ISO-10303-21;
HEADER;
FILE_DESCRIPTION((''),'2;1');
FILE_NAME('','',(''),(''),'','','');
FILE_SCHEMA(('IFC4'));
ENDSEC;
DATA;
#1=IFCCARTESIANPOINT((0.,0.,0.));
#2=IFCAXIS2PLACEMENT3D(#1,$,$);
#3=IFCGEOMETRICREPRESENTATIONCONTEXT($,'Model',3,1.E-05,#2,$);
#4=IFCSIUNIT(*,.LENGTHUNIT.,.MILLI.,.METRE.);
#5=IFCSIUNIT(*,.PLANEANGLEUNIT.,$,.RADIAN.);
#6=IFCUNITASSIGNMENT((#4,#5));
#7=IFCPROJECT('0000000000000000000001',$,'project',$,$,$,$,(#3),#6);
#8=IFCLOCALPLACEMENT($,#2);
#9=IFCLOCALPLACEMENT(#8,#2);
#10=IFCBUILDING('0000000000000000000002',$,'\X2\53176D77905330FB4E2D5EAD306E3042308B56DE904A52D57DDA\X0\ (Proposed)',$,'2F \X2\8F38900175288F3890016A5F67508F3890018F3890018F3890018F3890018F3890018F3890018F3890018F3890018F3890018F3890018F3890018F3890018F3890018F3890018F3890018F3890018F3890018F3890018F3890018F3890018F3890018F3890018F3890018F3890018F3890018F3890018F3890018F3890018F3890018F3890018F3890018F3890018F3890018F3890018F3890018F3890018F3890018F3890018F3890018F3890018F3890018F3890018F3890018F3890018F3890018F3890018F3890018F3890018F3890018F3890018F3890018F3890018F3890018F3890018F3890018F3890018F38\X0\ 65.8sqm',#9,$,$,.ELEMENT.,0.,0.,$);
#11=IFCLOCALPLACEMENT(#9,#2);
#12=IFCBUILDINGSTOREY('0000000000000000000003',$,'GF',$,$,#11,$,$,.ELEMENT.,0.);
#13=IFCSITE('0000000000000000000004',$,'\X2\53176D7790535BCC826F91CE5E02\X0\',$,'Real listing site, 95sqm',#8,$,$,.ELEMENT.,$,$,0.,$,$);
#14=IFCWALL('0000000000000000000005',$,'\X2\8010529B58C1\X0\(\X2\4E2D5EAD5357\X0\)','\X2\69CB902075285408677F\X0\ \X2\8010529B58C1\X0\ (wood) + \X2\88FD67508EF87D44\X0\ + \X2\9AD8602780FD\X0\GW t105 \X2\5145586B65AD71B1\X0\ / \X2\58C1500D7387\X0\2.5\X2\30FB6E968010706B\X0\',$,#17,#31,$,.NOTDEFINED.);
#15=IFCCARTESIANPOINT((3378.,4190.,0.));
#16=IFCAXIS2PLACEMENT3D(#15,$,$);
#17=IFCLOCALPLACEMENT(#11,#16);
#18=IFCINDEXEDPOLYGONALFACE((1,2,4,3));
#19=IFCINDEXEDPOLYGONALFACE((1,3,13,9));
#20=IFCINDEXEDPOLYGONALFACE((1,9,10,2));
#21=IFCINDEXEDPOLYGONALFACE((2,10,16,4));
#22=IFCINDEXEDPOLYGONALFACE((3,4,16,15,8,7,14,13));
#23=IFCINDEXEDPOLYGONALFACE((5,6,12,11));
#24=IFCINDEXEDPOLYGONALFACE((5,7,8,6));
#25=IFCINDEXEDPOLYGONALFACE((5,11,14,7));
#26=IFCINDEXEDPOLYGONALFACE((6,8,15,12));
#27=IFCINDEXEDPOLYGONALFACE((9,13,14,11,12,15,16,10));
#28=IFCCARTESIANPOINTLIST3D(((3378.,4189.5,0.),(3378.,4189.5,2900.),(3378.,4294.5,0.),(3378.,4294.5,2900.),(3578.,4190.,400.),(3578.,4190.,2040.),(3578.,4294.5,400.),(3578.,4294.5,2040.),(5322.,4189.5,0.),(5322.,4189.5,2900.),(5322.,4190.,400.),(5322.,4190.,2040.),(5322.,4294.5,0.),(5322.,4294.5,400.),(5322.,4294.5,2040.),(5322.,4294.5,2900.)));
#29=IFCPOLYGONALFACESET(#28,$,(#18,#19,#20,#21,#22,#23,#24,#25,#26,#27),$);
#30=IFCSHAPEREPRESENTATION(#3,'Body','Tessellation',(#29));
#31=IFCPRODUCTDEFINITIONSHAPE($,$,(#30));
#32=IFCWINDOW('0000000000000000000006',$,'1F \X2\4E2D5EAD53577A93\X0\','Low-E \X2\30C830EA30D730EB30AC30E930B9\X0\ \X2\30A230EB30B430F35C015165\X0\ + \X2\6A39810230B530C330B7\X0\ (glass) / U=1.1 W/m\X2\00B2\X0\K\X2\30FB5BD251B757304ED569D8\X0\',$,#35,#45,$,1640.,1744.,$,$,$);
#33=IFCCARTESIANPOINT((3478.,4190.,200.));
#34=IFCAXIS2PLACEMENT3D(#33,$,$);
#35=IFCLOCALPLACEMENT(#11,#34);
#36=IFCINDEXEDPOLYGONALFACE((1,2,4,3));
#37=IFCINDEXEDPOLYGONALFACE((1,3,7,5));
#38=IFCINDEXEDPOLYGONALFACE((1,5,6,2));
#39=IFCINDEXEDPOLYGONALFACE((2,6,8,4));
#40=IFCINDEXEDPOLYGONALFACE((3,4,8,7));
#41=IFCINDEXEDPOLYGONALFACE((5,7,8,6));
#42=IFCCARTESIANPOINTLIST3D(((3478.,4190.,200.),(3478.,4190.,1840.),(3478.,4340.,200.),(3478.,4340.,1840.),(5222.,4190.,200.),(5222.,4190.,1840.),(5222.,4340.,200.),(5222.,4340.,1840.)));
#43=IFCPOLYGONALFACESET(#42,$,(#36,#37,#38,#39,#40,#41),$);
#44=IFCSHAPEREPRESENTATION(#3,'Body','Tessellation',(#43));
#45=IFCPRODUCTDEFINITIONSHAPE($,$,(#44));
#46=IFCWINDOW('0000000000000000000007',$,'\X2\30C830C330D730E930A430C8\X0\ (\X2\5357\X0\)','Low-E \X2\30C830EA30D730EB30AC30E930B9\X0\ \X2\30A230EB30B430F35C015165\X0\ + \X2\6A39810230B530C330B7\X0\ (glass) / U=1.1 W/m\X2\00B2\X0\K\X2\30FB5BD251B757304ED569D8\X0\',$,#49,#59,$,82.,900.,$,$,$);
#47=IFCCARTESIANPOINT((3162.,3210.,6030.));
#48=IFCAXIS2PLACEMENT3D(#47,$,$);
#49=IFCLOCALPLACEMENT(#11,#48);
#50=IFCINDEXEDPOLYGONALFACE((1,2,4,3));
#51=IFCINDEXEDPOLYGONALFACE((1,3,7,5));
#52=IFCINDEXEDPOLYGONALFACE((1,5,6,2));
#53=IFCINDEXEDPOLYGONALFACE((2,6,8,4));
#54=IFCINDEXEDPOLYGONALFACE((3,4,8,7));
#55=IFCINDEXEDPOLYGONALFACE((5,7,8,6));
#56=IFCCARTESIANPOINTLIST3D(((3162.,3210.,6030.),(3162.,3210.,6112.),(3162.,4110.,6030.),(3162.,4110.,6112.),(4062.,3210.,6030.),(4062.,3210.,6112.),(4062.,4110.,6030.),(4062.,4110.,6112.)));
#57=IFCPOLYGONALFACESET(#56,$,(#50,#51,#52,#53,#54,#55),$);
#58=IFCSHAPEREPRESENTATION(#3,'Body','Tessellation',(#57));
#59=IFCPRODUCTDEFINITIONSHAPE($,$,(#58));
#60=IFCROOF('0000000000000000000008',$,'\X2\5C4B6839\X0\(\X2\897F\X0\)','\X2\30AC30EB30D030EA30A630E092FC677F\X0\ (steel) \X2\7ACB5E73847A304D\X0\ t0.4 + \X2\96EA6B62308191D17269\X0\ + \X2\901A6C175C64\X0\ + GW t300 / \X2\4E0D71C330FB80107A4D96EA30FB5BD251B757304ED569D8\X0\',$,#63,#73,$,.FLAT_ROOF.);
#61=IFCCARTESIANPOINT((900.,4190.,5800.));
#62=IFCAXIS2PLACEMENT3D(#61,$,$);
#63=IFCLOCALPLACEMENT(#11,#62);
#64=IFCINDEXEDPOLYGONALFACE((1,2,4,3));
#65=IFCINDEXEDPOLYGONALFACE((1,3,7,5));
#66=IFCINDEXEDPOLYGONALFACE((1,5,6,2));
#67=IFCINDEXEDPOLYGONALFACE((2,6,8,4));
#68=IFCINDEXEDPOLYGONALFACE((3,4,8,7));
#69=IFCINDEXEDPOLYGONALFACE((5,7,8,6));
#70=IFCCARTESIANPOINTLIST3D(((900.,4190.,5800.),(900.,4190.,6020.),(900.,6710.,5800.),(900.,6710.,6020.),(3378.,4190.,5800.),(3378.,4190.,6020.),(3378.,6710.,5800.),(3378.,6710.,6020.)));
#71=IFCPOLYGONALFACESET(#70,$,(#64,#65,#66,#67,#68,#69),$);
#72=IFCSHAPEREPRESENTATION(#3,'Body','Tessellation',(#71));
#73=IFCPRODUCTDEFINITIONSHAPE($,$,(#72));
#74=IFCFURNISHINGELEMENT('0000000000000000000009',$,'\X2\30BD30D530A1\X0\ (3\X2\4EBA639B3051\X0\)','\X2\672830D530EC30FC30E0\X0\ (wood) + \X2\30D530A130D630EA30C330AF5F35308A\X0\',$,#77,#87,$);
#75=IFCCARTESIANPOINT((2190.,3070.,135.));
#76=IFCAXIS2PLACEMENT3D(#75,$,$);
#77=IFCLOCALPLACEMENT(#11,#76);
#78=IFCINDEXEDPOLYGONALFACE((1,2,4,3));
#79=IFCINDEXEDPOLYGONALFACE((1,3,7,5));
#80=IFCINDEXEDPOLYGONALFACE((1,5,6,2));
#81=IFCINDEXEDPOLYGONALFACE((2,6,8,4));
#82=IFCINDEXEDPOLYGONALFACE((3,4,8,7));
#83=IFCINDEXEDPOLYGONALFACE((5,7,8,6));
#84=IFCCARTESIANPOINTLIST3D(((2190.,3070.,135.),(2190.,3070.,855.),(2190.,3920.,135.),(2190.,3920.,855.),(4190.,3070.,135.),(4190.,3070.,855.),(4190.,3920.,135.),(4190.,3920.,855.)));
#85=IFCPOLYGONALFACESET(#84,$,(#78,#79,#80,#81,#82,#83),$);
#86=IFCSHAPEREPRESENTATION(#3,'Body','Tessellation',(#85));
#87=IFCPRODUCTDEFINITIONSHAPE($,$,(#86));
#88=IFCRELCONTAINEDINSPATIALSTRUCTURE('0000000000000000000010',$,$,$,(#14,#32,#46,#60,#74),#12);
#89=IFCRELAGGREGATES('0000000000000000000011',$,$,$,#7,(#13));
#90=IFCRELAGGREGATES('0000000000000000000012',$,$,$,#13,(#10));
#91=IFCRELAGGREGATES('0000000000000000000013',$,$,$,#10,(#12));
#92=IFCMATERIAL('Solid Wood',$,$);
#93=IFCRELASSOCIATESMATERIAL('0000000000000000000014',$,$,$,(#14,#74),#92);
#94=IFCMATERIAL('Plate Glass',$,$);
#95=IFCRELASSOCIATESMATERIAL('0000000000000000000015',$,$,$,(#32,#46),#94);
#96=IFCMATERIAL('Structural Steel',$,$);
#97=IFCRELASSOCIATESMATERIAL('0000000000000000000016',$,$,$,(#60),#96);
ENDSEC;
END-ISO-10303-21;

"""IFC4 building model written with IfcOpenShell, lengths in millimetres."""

from ifc_helpers import new_model, si_unit, frame, frame_2d, origin, place, context, project, spatial, rectangle, extrude, material, element, fill, save


model = new_model("IFC4")

# Units and contexts
model_context = context("Model", 3, precision=1e-05, world=origin())
ifc_project = project(units=[si_unit("LENGTHUNIT", "METRE", prefix="MILLI"), si_unit("PLANEANGLEUNIT", "RADIAN")], contexts=[model_context])

# Site, building, storey
site_placement = place(None, origin())
site = spatial("IfcSite", under=ifc_project, at=site_placement, Name="北海道富良野市", ObjectType="Real listing site, 95sqm", CompositionType="ELEMENT", RefElevation=0.0)
building_placement = place(site_placement, origin())
building = spatial("IfcBuilding", under=site, at=building_placement, Name="北海道・中庭のある回遊動線 (Proposed)", ObjectType="2F 輸送用輸送機材輸送輸送輸送輸送輸送輸送輸送輸送輸送輸送輸送輸送輸送輸送輸送輸送輸送輸送輸送輸送輸送輸送輸送輸送輸送輸送輸送輸送輸送輸送輸送輸送輸送輸送輸送輸送輸送輸送輸送輸送輸送輸送輸送輸送輸送輸送輸送輸送輸送輸送輸送輸送輸送輸送輸送輸送輸 65.8sqm", CompositionType="ELEMENT", ElevationOfRefHeight=0.0, ElevationOfTerrain=0.0)
storey_placement = place(building_placement, origin())
storey = spatial("IfcBuildingStorey", under=building, at=storey_placement, Name="GF", CompositionType="ELEMENT", Elevation=0.0)

# Shared definitions
ifc_material_1 = material(Name="Solid Wood")

# Wall, opening, window
wall_placement = place(storey_placement, frame((3378.0, 4190.0, 0.0)))
wall = element("IfcWall", 1, at=wall_placement, inside=storey, material=ifc_material_1, Name="耐力壁(中庭南)", Description="構造用合板 耐力壁 (wood) + 製材軸組 + 高性能GW t105 充填断熱 / 壁倍率2.5・準耐火", PredefinedType="NOTDEFINED", context=model_context, shape_type="SweptSolid", body=[
    extrude(rectangle(XDim=1944.0, YDim=105.0, at=frame_2d((972.0, 52.0))), frame((3378.0, 4190.0, 0.0)), (0.0, 0.0, 1.0), 2900.0),
])
opening_placement = place(storey_placement, frame((3478.0, 4190.0, 200.0)))
opening = element("IfcOpeningElement", 2, at=opening_placement, cuts=wall, PredefinedType="NOTDEFINED", context=model_context, shape_type="SweptSolid", body=[
    extrude(rectangle(XDim=1744.0, YDim=150.0, at=frame_2d((872.0, 75.0))), frame((3478.0, 4190.0, 200.0)), (0.0, 0.0, 1.0), 1640.0),
])
ifc_material_2 = material(Name="Plate Glass")
window_1_placement = place(storey_placement, frame((3478.0, 4190.0, 200.0)))
window_1 = element("IfcWindow", 3, at=window_1_placement, inside=storey, material=ifc_material_2, Name="1F 中庭南窓", Description="Low-E トリプルガラス アルゴン封入 + 樹脂サッシ (glass) / U=1.1 W/m²K・寒冷地仕様", OverallHeight=1640.0, OverallWidth=1744.0, context=model_context, shape_type="SweptSolid", body=[
    extrude(rectangle(XDim=1744.0, YDim=150.0, at=frame_2d((872.0, 75.0))), frame((3478.0, 4190.0, 200.0)), (0.0, 0.0, 1.0), 1640.0),
])
fill(opening, window_1)

# Window
window_2_placement = place(storey_placement, frame((3162.0, 3210.0, 6030.0)))
element("IfcWindow", 4, at=window_2_placement, inside=storey, material=ifc_material_2, Name="トップライト (南)", Description="Low-E トリプルガラス アルゴン封入 + 樹脂サッシ (glass) / U=1.1 W/m²K・寒冷地仕様", OverallHeight=82.0, OverallWidth=900.0, context=model_context, shape_type="SweptSolid", body=[
    extrude(rectangle(XDim=900.0, YDim=900.0, at=frame_2d((450.0, 450.0))), frame((3162.0, 3210.0, 6030.0)), (0.0, 0.0, 1.0), 82.0),
])

# Roof
ifc_material_3 = material(Name="Structural Steel")
for number, where, name in (
    (5, (900.0, 4190.0, 5800.0), "屋根(西)"),
):
    element("IfcRoof", number, at=place(storey_placement, frame(where)), inside=storey, material=ifc_material_3, Name=name, Description="ガルバリウム鋼板 (steel) 立平葺き t0.4 + 雪止め金物 + 通気層 + GW t300 / 不燃・耐積雪・寒冷地仕様", PredefinedType="FLAT_ROOF", context=model_context, shape_type="SweptSolid", body=[
        extrude(rectangle(XDim=2478.0, YDim=2520.0, at=frame_2d((1239.0, 1260.0))), frame((900.0, 4190.0, 5800.0)), (0.0, 0.0, 1.0), 220.0),
    ])

# Furnishing element
furnishing_placement = place(storey_placement, frame((2190.0, 3070.0, 135.0)))
element("IfcFurnishingElement", 6, at=furnishing_placement, inside=storey, material=ifc_material_1, Name="ソファ (3人掛け)", Description="木フレーム (wood) + ファブリック張り", context=model_context, shape_type="SweptSolid", body=[
    extrude(rectangle(XDim=2000.0, YDim=850.0, at=frame_2d((1000.0, 425.0))), frame((2190.0, 3070.0, 135.0)), (0.0, 0.0, 1.0), 720.0),
])

save(model, "model.ifc")
